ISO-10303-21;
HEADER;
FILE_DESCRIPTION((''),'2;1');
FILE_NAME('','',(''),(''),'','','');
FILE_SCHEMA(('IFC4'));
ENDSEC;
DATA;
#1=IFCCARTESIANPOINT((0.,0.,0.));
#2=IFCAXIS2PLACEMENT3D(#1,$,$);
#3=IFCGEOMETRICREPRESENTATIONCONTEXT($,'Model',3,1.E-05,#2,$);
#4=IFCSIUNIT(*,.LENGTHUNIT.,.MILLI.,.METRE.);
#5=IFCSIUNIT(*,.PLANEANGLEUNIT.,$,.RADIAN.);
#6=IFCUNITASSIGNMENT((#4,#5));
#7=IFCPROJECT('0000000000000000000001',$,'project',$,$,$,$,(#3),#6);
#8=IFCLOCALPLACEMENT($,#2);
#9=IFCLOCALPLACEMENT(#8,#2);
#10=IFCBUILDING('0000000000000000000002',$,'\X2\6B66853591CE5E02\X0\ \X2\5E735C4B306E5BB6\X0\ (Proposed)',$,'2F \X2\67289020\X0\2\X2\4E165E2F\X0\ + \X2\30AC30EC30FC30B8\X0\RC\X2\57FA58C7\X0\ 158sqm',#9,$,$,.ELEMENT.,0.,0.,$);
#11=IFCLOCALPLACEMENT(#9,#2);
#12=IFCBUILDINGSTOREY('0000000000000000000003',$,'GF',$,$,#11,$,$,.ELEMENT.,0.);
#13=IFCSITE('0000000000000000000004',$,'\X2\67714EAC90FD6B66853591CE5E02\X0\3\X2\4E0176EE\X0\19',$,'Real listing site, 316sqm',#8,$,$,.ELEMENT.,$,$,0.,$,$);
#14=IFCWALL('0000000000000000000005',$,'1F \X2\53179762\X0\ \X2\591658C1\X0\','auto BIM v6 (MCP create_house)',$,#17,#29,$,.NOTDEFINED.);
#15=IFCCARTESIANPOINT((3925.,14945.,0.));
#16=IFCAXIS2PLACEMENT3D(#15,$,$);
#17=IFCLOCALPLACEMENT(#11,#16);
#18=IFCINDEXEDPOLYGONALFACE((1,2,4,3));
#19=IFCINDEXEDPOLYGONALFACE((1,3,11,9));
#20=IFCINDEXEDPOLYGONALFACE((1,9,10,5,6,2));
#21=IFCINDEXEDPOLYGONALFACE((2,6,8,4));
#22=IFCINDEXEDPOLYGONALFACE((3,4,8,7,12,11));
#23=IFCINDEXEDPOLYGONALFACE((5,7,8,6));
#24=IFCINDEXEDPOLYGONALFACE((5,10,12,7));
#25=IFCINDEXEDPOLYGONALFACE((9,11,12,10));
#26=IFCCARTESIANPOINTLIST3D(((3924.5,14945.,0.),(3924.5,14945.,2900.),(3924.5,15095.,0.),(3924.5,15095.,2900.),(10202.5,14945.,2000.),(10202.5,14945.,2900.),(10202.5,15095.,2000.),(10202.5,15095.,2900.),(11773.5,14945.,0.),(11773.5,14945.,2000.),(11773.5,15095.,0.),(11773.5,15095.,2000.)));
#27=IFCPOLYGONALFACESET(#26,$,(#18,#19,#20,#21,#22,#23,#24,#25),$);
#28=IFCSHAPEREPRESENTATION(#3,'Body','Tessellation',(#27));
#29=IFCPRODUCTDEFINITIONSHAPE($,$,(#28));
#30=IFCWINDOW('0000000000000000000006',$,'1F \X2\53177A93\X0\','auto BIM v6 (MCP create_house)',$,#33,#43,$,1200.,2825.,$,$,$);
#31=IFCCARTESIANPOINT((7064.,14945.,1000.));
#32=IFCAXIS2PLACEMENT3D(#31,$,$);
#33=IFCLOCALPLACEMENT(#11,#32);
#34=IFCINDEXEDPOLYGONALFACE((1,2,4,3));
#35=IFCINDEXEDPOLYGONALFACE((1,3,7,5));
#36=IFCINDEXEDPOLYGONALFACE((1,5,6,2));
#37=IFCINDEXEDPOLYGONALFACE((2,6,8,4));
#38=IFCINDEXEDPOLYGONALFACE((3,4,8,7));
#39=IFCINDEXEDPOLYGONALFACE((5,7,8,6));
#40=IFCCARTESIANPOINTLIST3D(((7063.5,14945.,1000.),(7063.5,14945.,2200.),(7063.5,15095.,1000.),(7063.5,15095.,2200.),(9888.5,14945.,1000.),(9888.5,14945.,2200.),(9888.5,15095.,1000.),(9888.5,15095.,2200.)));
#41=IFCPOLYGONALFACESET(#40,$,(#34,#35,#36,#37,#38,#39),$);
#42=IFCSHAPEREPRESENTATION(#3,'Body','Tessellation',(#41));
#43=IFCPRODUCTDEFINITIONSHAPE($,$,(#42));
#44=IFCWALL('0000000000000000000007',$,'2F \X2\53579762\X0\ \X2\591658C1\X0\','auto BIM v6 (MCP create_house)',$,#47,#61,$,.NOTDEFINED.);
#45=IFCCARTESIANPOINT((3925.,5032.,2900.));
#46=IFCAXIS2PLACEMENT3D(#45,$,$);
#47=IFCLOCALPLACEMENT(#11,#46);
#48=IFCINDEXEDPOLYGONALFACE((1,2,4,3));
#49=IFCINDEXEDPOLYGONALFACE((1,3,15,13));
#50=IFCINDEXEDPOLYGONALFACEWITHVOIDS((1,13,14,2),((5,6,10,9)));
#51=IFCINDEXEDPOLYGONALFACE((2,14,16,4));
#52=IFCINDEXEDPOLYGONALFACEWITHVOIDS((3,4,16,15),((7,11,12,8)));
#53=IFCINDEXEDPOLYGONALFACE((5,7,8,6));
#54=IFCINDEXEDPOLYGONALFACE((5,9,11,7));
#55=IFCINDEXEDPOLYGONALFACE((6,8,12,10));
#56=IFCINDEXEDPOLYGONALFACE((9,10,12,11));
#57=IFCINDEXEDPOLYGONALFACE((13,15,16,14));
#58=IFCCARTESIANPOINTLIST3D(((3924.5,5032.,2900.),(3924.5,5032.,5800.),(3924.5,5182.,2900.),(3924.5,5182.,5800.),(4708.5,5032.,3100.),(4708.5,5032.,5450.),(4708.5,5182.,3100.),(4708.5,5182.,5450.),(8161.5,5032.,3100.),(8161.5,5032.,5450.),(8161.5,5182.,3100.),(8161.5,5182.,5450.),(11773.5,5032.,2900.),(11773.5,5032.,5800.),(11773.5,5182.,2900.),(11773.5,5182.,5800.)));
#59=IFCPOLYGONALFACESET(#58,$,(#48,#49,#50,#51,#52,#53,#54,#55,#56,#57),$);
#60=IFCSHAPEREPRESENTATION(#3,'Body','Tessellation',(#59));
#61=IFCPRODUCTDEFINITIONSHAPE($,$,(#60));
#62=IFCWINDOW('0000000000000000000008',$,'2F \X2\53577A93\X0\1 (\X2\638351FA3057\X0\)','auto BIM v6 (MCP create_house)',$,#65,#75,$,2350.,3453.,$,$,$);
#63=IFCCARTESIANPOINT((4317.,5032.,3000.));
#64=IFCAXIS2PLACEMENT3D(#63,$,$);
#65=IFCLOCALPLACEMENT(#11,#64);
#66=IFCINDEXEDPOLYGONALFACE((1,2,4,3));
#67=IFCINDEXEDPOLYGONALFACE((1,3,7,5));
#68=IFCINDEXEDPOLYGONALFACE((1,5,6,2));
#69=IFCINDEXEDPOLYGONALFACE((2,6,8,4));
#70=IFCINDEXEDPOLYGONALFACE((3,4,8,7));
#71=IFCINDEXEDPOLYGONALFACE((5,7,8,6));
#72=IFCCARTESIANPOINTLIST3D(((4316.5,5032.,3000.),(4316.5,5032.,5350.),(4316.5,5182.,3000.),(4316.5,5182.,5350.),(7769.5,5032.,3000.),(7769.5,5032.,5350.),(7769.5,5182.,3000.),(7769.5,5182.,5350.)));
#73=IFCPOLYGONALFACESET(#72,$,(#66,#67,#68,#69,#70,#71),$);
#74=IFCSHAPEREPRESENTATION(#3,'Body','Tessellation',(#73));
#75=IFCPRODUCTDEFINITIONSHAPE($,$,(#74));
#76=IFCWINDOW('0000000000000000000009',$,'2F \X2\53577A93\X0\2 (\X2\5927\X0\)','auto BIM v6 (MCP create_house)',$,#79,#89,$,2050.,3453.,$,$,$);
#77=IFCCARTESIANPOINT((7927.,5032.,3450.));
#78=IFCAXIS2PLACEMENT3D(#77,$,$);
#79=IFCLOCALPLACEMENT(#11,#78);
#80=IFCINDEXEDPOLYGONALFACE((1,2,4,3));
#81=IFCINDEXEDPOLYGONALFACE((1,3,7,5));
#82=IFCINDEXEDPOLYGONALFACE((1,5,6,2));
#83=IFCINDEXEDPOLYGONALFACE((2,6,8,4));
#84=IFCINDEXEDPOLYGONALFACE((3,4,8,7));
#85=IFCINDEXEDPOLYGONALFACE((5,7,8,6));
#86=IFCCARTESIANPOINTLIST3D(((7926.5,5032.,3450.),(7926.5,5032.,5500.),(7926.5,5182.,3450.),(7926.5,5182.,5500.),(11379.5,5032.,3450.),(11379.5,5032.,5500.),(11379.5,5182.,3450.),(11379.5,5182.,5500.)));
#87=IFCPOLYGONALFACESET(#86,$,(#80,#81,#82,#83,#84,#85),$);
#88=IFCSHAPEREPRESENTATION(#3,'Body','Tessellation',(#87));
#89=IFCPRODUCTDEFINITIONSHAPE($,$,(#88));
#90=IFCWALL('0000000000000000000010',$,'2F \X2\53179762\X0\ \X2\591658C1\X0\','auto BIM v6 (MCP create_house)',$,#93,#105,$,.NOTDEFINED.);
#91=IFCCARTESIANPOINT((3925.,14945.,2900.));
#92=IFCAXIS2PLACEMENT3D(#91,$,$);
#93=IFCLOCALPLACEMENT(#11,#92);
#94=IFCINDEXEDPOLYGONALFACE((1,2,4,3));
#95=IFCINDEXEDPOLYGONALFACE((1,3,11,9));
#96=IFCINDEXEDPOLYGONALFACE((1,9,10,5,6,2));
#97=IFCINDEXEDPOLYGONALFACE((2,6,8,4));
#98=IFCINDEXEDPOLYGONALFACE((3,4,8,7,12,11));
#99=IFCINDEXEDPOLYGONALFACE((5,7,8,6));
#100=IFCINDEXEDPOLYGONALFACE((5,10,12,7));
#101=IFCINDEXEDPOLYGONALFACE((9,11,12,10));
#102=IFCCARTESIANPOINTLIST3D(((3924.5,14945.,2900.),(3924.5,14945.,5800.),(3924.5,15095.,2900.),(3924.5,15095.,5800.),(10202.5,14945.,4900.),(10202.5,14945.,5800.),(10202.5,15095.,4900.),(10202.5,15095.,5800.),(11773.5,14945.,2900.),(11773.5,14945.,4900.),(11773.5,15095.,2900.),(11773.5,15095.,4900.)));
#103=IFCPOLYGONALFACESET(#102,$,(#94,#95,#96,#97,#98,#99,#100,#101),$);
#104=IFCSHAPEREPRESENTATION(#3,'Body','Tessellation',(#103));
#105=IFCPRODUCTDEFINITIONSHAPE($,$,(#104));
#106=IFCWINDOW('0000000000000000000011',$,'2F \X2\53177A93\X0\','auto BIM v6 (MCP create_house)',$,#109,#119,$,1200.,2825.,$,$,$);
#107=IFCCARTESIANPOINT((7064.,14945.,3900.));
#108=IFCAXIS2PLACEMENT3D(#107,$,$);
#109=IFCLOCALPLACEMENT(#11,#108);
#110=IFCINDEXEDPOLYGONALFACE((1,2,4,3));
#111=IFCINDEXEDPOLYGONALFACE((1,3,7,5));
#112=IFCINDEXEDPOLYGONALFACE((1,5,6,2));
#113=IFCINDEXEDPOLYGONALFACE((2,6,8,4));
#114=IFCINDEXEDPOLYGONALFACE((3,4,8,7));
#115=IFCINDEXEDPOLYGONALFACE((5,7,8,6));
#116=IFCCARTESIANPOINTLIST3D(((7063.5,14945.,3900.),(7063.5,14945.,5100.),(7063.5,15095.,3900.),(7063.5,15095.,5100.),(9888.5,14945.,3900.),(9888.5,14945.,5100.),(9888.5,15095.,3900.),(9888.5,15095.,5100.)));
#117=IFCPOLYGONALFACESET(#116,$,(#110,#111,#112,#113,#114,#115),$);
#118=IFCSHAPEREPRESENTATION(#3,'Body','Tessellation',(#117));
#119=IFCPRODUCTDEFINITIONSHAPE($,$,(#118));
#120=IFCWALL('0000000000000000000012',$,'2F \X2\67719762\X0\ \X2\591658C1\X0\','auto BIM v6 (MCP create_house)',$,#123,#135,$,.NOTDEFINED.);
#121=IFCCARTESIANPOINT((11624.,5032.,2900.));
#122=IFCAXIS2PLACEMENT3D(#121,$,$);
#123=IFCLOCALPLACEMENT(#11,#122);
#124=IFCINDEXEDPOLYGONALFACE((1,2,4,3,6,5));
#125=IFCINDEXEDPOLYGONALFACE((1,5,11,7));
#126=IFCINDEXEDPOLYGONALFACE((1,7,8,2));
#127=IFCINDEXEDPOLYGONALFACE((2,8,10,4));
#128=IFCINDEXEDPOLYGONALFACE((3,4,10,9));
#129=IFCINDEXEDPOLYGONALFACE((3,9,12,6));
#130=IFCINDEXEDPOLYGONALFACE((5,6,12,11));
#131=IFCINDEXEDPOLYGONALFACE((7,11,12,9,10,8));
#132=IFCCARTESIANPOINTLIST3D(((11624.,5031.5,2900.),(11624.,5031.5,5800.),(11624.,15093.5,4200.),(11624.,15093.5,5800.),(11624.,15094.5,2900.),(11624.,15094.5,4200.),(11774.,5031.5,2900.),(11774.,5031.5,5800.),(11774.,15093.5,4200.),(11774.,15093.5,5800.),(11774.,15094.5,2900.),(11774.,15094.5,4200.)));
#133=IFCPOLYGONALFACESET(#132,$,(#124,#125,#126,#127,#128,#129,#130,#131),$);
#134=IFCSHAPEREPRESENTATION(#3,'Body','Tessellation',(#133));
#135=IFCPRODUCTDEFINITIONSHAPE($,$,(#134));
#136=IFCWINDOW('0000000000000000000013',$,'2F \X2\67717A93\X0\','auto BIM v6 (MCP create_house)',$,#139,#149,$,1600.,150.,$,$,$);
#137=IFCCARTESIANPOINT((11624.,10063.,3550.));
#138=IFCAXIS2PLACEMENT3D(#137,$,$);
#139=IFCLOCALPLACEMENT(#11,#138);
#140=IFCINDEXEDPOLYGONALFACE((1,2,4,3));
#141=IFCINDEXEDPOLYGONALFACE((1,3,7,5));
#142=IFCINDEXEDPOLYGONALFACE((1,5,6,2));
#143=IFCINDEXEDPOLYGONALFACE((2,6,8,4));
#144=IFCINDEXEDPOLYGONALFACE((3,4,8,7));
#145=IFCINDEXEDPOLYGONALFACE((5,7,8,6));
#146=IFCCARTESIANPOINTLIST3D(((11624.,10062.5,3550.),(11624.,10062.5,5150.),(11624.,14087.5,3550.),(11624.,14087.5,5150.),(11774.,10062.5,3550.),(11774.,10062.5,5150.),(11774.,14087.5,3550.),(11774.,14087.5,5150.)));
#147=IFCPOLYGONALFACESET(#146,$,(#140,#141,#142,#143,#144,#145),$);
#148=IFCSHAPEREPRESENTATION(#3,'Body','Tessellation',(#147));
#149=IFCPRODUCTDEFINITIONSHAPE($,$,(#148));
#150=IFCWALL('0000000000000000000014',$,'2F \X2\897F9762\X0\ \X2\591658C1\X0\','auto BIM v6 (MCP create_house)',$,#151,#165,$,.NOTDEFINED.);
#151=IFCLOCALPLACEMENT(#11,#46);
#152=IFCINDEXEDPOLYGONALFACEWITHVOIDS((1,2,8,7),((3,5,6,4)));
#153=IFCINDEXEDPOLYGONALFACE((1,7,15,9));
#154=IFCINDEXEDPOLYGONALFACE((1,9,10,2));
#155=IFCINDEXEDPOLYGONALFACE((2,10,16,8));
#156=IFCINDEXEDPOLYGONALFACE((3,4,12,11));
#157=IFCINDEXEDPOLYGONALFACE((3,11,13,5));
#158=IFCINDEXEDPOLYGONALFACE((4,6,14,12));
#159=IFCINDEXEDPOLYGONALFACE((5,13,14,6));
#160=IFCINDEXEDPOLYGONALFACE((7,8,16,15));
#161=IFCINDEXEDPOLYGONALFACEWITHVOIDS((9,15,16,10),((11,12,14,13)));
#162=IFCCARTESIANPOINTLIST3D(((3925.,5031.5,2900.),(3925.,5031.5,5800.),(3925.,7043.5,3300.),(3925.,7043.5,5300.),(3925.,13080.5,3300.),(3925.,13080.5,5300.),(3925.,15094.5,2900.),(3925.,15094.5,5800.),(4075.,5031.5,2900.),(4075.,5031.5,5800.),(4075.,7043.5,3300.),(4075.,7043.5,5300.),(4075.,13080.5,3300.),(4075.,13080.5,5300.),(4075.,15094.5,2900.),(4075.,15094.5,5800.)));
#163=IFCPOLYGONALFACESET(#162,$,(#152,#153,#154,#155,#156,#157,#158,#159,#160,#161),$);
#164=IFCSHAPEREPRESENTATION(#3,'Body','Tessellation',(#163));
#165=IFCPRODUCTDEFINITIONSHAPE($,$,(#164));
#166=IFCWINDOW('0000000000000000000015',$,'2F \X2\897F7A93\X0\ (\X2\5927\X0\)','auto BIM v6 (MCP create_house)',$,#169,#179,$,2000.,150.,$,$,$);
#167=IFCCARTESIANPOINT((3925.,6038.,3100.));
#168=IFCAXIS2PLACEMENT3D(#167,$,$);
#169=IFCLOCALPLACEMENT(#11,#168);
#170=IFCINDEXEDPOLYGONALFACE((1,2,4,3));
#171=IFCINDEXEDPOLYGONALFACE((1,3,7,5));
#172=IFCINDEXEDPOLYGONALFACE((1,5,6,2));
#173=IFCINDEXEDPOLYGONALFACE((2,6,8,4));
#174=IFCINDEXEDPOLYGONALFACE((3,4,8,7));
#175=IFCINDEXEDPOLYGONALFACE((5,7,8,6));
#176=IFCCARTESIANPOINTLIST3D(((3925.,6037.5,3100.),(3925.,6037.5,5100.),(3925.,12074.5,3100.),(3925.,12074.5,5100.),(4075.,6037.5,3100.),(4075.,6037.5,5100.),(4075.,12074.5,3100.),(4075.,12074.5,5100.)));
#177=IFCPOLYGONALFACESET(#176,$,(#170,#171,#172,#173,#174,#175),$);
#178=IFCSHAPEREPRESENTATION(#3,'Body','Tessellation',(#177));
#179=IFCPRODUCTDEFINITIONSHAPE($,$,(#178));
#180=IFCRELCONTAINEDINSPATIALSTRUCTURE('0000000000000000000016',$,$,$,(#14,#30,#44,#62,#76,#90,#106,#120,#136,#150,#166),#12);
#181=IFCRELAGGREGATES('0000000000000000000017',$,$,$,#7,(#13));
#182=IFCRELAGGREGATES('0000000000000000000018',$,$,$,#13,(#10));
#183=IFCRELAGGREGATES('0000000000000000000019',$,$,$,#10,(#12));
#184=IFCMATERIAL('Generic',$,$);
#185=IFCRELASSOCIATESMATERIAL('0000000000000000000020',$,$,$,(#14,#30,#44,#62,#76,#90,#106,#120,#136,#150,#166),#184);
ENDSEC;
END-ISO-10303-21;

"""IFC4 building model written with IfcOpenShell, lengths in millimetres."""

from ifc_helpers import new_model, si_unit, frame, frame_2d, origin, place, context, project, spatial, rectangle, extrude, material, element, fill, save


model = new_model("IFC4")

# Units and contexts
model_context = context("Model", 3, precision=1e-05, world=origin())
ifc_project = project(units=[si_unit("LENGTHUNIT", "METRE", prefix="MILLI"), si_unit("PLANEANGLEUNIT", "RADIAN")], contexts=[model_context])

# Site, building, storey
site_placement = place(None, origin())
site = spatial("IfcSite", under=ifc_project, at=site_placement, Name="東京都武蔵野市3丁目19", ObjectType="Real listing site, 316sqm", CompositionType="ELEMENT", RefElevation=0.0)
building_placement = place(site_placement, origin())
building = spatial("IfcBuilding", under=site, at=building_placement, Name="武蔵野市 平屋の家 (Proposed)", ObjectType="2F 木造2世帯 + ガレージRC基壇 158sqm", CompositionType="ELEMENT", ElevationOfRefHeight=0.0, ElevationOfTerrain=0.0)
storey_placement = place(building_placement, origin())
storey = spatial("IfcBuildingStorey", under=building, at=storey_placement, Name="GF", CompositionType="ELEMENT", Elevation=0.0)

# Wall, opening, window
ifc_material = material(Name="Generic")
wall_1_placement = place(storey_placement, frame((3925.0, 14945.0, 0.0)))
wall_1 = element("IfcWall", 1, at=wall_1_placement, inside=storey, material=ifc_material, Name="1F 北面 外壁", Description="auto BIM v6 (MCP create_house)", PredefinedType="NOTDEFINED", context=model_context, shape_type="SweptSolid", body=[
    extrude(rectangle(XDim=7849.0, YDim=150.0, at=frame_2d((3924.0, 75.0))), frame((3925.0, 14945.0, 0.0)), (0.0, 0.0, 1.0), 2900.0),
])
opening_1_placement = place(storey_placement, frame((7064.0, 14945.0, 1000.0)))
opening_1 = element("IfcOpeningElement", 2, at=opening_1_placement, cuts=wall_1, PredefinedType="NOTDEFINED", context=model_context, shape_type="SweptSolid", body=[
    extrude(rectangle(XDim=2825.0, YDim=150.0, at=frame_2d((1412.0, 75.0))), frame((7064.0, 14945.0, 1000.0)), (0.0, 0.0, 1.0), 1200.0),
])
window_1_placement = place(storey_placement, frame((7064.0, 14945.0, 1000.0)))
window_1 = element("IfcWindow", 3, at=window_1_placement, inside=storey, material=ifc_material, Name="1F 北窓", Description="auto BIM v6 (MCP create_house)", OverallHeight=1200.0, OverallWidth=2825.0, context=model_context, shape_type="SweptSolid", body=[
    extrude(rectangle(XDim=2825.0, YDim=150.0, at=frame_2d((1412.0, 75.0))), frame((7064.0, 14945.0, 1000.0)), (0.0, 0.0, 1.0), 1200.0),
])
fill(opening_1, window_1)

# Wall, openings, windows
wall_2_placement = place(storey_placement, frame((3925.0, 5032.0, 2900.0)))
wall_2 = element("IfcWall", 4, at=wall_2_placement, inside=storey, material=ifc_material, Name="2F 南面 外壁", Description="auto BIM v6 (MCP create_house)", PredefinedType="NOTDEFINED", context=model_context, shape_type="SweptSolid", body=[
    extrude(rectangle(XDim=7849.0, YDim=150.0, at=frame_2d((3924.0, 75.0))), frame((3925.0, 5032.0, 2900.0)), (0.0, 0.0, 1.0), 2900.0),
])
opening_2_placement = place(storey_placement, frame((4317.0, 5032.0, 3000.0)))
opening_2 = element("IfcOpeningElement", 5, at=opening_2_placement, cuts=wall_2, PredefinedType="NOTDEFINED", context=model_context, shape_type="SweptSolid", body=[
    extrude(rectangle(XDim=3453.0, YDim=150.0, at=frame_2d((1726.0, 75.0))), frame((4317.0, 5032.0, 3000.0)), (0.0, 0.0, 1.0), 2350.0),
])
opening_3_placement = place(storey_placement, frame((7927.0, 5032.0, 3450.0)))
opening_3 = element("IfcOpeningElement", 6, at=opening_3_placement, cuts=wall_2, PredefinedType="NOTDEFINED", context=model_context, shape_type="SweptSolid", body=[
    extrude(rectangle(XDim=3453.0, YDim=150.0, at=frame_2d((1726.0, 75.0))), frame((7927.0, 5032.0, 3450.0)), (0.0, 0.0, 1.0), 2050.0),
])
window_2_placement = place(storey_placement, frame((4317.0, 5032.0, 3000.0)))
window_2 = element("IfcWindow", 7, at=window_2_placement, inside=storey, material=ifc_material, Name="2F 南窓1 (掃出し)", Description="auto BIM v6 (MCP create_house)", OverallHeight=2350.0, OverallWidth=3453.0, context=model_context, shape_type="SweptSolid", body=[
    extrude(rectangle(XDim=3453.0, YDim=150.0, at=frame_2d((1726.0, 75.0))), frame((4317.0, 5032.0, 3000.0)), (0.0, 0.0, 1.0), 2350.0),
])
fill(opening_2, window_2)
window_3_placement = place(storey_placement, frame((7927.0, 5032.0, 3450.0)))
window_3 = element("IfcWindow", 8, at=window_3_placement, inside=storey, material=ifc_material, Name="2F 南窓2 (大)", Description="auto BIM v6 (MCP create_house)", OverallHeight=2050.0, OverallWidth=3453.0, context=model_context, shape_type="SweptSolid", body=[
    extrude(rectangle(XDim=3453.0, YDim=150.0, at=frame_2d((1726.0, 75.0))), frame((7927.0, 5032.0, 3450.0)), (0.0, 0.0, 1.0), 2050.0),
])
fill(opening_3, window_3)

# Walls, openings, windows
wall_3_placement = place(storey_placement, frame((3925.0, 14945.0, 2900.0)))
wall_3 = element("IfcWall", 9, at=wall_3_placement, inside=storey, material=ifc_material, Name="2F 北面 外壁", Description="auto BIM v6 (MCP create_house)", PredefinedType="NOTDEFINED", context=model_context, shape_type="SweptSolid", body=[
    extrude(rectangle(XDim=7849.0, YDim=150.0, at=frame_2d((3924.0, 75.0))), frame((3925.0, 14945.0, 2900.0)), (0.0, 0.0, 1.0), 2900.0),
])
opening_4_placement = place(storey_placement, frame((7064.0, 14945.0, 3900.0)))
opening_4 = element("IfcOpeningElement", 10, at=opening_4_placement, cuts=wall_3, PredefinedType="NOTDEFINED", context=model_context, shape_type="SweptSolid", body=[
    extrude(rectangle(XDim=2825.0, YDim=150.0, at=frame_2d((1412.0, 75.0))), frame((7064.0, 14945.0, 3900.0)), (0.0, 0.0, 1.0), 1200.0),
])
window_4_placement = place(storey_placement, frame((7064.0, 14945.0, 3900.0)))
window_4 = element("IfcWindow", 11, at=window_4_placement, inside=storey, material=ifc_material, Name="2F 北窓", Description="auto BIM v6 (MCP create_house)", OverallHeight=1200.0, OverallWidth=2825.0, context=model_context, shape_type="SweptSolid", body=[
    extrude(rectangle(XDim=2825.0, YDim=150.0, at=frame_2d((1412.0, 75.0))), frame((7064.0, 14945.0, 3900.0)), (0.0, 0.0, 1.0), 1200.0),
])
fill(opening_4, window_4)
wall_4_placement = place(storey_placement, frame((11624.0, 5032.0, 2900.0)))
wall_4 = element("IfcWall", 12, at=wall_4_placement, inside=storey, material=ifc_material, Name="2F 東面 外壁", Description="auto BIM v6 (MCP create_house)", PredefinedType="NOTDEFINED", context=model_context, shape_type="SweptSolid", body=[
    extrude(rectangle(XDim=150.0, YDim=10063.0, at=frame_2d((75.0, 5031.0))), frame((11624.0, 5032.0, 2900.0)), (0.0, 0.0, 1.0), 2900.0),
])
opening_5_placement = place(storey_placement, frame((11624.0, 10063.0, 3550.0)))
opening_5 = element("IfcOpeningElement", 13, at=opening_5_placement, cuts=wall_4, PredefinedType="NOTDEFINED", context=model_context, shape_type="SweptSolid", body=[
    extrude(rectangle(XDim=150.0, YDim=4025.0, at=frame_2d((75.0, 2012.0))), frame((11624.0, 10063.0, 3550.0)), (0.0, 0.0, 1.0), 1600.0),
])
window_5_placement = place(storey_placement, frame((11624.0, 10063.0, 3550.0)))
window_5 = element("IfcWindow", 14, at=window_5_placement, inside=storey, material=ifc_material, Name="2F 東窓", Description="auto BIM v6 (MCP create_house)", OverallHeight=1600.0, OverallWidth=150.0, context=model_context, shape_type="SweptSolid", body=[
    extrude(rectangle(XDim=150.0, YDim=4025.0, at=frame_2d((75.0, 2012.0))), frame((11624.0, 10063.0, 3550.0)), (0.0, 0.0, 1.0), 1600.0),
])
fill(opening_5, window_5)
wall_5_placement = place(storey_placement, frame((3925.0, 5032.0, 2900.0)))
wall_5 = element("IfcWall", 15, at=wall_5_placement, inside=storey, material=ifc_material, Name="2F 西面 外壁", Description="auto BIM v6 (MCP create_house)", PredefinedType="NOTDEFINED", context=model_context, shape_type="SweptSolid", body=[
    extrude(rectangle(XDim=150.0, YDim=10063.0, at=frame_2d((75.0, 5031.0))), frame((3925.0, 5032.0, 2900.0)), (0.0, 0.0, 1.0), 2900.0),
])
opening_6_placement = place(storey_placement, frame((3925.0, 6038.0, 3100.0)))
opening_6 = element("IfcOpeningElement", 16, at=opening_6_placement, cuts=wall_5, PredefinedType="NOTDEFINED", context=model_context, shape_type="SweptSolid", body=[
    extrude(rectangle(XDim=150.0, YDim=6037.0, at=frame_2d((75.0, 3018.0))), frame((3925.0, 6038.0, 3100.0)), (0.0, 0.0, 1.0), 2000.0),
])
window_6_placement = place(storey_placement, frame((3925.0, 6038.0, 3100.0)))
window_6 = element("IfcWindow", 17, at=window_6_placement, inside=storey, material=ifc_material, Name="2F 西窓 (大)", Description="auto BIM v6 (MCP create_house)", OverallHeight=2000.0, OverallWidth=150.0, context=model_context, shape_type="SweptSolid", body=[
    extrude(rectangle(XDim=150.0, YDim=6037.0, at=frame_2d((75.0, 3018.0))), frame((3925.0, 6038.0, 3100.0)), (0.0, 0.0, 1.0), 2000.0),
])
fill(opening_6, window_6)

save(model, "model.ifc")
